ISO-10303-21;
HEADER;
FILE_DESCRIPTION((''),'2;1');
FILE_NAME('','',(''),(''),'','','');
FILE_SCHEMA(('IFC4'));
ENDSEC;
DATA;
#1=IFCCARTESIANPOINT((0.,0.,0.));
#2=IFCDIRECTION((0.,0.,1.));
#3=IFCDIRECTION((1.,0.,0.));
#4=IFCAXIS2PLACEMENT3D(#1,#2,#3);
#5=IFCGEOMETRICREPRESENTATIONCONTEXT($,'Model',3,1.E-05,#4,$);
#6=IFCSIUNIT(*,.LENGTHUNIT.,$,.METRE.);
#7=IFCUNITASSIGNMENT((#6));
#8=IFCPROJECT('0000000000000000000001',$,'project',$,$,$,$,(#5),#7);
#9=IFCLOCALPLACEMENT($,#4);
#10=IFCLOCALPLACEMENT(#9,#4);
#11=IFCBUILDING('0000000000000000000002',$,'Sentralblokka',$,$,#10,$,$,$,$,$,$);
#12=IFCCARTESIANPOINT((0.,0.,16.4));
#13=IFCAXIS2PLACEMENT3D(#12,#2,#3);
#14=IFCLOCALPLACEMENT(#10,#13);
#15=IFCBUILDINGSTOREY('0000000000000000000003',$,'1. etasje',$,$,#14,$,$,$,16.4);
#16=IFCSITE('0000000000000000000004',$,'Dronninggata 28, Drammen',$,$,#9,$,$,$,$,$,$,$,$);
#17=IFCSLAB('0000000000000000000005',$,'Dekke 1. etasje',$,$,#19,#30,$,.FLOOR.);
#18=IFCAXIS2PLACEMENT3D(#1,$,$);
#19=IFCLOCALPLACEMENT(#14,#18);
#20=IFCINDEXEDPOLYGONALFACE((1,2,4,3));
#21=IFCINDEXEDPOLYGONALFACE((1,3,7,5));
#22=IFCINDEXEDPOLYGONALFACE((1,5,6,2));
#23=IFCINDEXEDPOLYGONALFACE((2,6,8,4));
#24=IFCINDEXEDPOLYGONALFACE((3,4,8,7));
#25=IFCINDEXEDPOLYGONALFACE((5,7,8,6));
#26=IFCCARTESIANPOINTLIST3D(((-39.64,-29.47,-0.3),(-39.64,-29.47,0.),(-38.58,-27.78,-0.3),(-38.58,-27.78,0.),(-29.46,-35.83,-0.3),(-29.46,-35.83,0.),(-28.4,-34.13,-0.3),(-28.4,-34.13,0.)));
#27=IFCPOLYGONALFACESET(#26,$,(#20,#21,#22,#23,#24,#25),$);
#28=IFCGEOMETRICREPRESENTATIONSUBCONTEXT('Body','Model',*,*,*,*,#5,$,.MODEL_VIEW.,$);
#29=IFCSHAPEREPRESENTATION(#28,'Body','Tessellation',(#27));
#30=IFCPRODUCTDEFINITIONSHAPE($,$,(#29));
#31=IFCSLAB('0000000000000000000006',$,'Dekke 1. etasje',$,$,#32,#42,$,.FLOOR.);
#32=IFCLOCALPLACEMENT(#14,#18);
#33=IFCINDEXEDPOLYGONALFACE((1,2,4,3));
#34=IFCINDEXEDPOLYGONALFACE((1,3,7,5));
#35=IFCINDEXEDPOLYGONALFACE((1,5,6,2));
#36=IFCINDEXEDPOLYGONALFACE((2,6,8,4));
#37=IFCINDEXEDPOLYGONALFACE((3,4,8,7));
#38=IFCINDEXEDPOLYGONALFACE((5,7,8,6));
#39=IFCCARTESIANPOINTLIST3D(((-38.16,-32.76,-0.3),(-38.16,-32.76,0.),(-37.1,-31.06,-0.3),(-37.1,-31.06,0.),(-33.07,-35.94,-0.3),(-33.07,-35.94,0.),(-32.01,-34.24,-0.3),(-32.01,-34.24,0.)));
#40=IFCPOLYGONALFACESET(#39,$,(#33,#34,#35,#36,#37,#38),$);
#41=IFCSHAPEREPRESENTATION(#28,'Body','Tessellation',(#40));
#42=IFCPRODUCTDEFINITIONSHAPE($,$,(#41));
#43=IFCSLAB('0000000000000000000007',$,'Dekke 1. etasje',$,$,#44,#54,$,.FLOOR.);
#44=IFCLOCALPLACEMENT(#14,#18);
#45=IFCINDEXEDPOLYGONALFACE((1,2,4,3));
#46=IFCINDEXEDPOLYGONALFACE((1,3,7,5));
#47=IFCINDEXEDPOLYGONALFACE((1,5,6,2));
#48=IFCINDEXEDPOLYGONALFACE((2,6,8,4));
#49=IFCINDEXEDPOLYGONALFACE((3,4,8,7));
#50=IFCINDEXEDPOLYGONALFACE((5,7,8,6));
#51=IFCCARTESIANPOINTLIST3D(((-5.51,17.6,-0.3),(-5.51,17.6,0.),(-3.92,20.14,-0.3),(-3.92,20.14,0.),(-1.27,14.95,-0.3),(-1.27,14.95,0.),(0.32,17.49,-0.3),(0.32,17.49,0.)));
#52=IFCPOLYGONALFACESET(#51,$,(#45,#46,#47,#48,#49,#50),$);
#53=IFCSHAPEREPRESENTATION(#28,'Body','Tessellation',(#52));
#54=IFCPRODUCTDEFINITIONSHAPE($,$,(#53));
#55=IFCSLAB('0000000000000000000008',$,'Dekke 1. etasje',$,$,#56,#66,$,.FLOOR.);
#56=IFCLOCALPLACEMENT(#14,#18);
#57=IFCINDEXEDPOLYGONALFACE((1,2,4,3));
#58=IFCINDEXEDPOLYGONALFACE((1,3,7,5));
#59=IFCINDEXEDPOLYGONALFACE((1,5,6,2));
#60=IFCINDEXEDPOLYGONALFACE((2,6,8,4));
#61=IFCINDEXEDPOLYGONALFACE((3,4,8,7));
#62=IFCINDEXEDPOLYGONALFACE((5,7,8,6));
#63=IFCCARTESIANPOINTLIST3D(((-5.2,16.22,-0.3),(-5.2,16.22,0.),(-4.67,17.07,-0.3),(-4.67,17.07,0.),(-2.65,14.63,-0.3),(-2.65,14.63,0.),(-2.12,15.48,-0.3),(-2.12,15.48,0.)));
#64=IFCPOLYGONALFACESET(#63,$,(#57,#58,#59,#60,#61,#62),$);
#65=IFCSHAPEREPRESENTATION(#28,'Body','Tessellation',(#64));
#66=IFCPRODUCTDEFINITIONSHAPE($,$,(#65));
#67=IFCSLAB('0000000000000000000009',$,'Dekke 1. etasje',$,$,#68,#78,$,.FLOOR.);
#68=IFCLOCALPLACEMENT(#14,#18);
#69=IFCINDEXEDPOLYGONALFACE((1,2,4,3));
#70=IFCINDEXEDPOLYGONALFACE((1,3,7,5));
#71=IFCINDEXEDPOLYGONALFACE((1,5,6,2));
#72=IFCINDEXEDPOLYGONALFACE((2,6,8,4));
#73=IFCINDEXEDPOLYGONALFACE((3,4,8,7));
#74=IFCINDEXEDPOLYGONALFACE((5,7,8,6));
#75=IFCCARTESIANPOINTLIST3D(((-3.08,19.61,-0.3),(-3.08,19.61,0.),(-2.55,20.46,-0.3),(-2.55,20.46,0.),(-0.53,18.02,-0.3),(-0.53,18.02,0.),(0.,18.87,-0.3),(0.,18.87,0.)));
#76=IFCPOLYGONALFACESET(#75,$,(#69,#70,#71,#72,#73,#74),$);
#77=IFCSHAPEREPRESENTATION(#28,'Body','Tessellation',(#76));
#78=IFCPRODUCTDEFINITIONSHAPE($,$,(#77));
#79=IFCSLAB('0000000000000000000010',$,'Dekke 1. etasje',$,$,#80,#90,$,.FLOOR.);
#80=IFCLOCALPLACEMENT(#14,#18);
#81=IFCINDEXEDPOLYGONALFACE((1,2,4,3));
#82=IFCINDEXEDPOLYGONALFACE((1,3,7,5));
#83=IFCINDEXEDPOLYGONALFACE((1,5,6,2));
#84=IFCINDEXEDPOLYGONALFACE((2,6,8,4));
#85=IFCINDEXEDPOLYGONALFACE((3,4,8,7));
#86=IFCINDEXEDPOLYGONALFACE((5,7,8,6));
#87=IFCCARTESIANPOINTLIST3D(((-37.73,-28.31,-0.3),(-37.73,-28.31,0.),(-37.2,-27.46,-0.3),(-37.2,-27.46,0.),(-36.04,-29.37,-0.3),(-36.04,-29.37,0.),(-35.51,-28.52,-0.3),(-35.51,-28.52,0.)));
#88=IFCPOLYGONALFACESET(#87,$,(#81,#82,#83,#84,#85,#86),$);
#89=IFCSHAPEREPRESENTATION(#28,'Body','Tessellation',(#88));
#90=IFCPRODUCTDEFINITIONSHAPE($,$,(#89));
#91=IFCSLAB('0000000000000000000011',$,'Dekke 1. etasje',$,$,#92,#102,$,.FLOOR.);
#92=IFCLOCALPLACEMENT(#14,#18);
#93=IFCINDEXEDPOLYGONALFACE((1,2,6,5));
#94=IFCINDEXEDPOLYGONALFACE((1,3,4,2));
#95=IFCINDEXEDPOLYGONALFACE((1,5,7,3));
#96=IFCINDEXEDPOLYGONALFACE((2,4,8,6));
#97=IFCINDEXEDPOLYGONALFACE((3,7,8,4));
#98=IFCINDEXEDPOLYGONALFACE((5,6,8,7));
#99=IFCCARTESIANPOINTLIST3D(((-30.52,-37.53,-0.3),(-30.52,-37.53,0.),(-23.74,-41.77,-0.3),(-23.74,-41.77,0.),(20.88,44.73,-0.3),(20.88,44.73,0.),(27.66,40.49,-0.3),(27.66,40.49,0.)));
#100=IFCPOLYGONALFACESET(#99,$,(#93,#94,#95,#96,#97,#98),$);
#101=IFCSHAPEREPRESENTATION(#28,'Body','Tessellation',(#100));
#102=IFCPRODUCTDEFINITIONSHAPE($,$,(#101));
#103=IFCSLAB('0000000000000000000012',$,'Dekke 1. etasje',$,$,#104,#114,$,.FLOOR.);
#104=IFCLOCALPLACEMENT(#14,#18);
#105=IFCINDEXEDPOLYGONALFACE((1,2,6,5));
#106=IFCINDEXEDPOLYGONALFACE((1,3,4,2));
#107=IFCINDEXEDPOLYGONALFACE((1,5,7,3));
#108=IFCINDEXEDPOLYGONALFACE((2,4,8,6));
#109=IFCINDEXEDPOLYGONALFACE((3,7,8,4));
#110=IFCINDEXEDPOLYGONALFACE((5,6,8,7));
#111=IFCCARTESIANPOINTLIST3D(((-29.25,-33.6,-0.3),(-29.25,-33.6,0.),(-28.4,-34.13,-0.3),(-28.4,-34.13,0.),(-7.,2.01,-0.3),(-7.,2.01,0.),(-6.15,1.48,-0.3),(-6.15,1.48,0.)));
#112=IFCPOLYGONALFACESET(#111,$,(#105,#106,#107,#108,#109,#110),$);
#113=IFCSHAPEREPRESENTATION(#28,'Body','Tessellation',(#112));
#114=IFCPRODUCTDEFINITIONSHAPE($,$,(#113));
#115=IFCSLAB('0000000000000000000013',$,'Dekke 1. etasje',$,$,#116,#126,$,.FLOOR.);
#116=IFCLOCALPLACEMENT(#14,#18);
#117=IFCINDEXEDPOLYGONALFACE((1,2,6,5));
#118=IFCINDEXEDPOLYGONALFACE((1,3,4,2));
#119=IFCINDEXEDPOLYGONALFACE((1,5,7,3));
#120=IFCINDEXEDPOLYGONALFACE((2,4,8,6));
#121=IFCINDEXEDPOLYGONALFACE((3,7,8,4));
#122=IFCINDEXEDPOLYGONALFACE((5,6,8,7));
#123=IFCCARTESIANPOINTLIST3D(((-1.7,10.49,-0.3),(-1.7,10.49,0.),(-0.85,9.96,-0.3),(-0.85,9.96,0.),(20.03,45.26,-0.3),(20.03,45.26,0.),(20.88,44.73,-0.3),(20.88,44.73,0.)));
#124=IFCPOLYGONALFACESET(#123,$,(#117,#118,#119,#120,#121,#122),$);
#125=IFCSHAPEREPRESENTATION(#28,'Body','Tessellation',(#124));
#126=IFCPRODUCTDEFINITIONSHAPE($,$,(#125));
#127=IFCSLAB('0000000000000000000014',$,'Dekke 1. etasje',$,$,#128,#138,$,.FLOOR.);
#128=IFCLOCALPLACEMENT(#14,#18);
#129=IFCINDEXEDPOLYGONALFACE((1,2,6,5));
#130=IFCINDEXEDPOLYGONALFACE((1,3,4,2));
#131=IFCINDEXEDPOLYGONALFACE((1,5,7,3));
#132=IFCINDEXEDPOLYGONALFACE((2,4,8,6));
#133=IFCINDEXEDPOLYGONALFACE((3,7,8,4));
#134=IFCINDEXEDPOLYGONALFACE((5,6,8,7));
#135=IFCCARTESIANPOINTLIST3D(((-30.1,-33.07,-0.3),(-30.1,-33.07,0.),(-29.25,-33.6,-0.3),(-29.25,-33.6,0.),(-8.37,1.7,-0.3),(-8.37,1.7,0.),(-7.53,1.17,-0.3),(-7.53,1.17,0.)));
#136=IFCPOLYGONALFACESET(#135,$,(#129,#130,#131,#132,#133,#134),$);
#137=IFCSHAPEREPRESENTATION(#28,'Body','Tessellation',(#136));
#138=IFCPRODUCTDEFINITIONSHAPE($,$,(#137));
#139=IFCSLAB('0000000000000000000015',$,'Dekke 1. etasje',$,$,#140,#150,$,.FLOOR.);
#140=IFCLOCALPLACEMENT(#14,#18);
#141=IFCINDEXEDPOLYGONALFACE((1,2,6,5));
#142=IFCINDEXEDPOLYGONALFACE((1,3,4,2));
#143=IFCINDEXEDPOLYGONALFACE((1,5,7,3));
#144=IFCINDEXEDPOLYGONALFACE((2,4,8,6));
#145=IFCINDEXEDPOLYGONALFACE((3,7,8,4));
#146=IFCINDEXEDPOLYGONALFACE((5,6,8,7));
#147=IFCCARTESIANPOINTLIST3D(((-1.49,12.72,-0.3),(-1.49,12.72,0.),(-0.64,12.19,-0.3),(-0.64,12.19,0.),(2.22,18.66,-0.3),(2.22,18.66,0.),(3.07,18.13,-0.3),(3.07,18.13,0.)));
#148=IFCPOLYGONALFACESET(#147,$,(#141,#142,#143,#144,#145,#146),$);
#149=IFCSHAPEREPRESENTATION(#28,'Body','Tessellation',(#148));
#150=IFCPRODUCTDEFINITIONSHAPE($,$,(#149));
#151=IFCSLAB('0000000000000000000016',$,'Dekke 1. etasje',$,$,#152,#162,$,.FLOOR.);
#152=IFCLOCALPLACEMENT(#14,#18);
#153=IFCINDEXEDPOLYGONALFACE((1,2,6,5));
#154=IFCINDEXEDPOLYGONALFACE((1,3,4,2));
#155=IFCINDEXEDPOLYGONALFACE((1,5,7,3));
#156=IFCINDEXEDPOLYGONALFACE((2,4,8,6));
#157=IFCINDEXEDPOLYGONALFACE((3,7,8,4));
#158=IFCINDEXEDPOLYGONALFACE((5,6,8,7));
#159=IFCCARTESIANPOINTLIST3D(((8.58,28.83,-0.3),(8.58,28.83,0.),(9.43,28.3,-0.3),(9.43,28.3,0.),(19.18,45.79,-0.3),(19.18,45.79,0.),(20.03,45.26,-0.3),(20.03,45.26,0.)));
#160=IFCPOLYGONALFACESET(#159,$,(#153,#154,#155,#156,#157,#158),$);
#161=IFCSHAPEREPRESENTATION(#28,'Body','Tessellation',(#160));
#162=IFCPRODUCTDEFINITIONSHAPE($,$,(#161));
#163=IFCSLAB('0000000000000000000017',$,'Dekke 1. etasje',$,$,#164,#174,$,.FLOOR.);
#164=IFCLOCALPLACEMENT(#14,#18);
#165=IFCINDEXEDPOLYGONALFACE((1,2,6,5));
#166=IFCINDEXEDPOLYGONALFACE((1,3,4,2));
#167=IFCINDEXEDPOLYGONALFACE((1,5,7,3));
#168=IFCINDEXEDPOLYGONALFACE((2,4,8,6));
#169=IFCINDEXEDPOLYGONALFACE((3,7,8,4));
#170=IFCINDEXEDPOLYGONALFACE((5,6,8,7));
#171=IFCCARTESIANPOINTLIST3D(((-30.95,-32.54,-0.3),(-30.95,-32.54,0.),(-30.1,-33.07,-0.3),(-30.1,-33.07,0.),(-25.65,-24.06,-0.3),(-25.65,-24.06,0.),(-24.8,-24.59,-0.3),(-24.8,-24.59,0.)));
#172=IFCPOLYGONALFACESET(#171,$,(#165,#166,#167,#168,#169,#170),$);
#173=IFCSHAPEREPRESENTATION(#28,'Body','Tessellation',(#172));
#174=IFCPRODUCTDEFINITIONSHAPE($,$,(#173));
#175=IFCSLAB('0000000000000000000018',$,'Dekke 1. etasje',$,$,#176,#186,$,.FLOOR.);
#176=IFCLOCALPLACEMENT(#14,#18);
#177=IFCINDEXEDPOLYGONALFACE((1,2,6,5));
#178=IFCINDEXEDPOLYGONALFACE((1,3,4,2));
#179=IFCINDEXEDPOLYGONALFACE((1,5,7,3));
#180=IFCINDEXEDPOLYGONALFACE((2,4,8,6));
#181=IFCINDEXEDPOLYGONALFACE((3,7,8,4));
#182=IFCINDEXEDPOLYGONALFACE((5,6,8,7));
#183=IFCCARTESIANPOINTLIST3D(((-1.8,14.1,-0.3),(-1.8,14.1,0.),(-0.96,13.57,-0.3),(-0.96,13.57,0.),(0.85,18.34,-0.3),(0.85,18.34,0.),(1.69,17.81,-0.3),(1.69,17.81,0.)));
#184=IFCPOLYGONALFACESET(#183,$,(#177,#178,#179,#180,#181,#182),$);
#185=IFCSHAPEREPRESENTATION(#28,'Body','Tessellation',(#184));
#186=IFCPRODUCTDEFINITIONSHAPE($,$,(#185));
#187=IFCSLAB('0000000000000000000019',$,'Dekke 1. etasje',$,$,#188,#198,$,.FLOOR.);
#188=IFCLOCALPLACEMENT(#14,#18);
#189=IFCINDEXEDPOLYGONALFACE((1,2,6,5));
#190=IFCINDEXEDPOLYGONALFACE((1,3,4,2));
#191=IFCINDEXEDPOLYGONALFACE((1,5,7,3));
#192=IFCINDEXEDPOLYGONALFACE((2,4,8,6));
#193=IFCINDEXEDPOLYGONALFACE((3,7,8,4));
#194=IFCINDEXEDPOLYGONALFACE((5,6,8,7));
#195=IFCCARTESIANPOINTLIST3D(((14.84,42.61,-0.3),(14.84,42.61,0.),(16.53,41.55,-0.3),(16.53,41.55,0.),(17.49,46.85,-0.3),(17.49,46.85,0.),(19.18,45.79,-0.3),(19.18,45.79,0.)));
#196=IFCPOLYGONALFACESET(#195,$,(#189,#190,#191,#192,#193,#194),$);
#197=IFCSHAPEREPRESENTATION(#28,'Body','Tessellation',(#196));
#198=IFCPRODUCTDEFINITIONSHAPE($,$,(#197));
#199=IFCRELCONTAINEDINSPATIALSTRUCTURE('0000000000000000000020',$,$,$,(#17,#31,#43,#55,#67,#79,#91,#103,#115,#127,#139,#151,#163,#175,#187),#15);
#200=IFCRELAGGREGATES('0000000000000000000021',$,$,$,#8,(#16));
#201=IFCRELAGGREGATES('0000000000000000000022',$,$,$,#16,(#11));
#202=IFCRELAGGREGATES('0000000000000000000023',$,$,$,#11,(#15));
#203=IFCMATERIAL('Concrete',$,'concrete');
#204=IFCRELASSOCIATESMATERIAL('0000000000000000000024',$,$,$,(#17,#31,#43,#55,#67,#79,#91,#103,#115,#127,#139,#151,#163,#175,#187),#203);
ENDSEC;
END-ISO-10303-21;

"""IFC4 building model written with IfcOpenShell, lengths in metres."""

from ifc_helpers import new_model, si_unit, frame, origin_with_axes, place, context, subcontext, project, spatial, polyline, outline, extrude, material, element, save


model = new_model("IFC4")

# Units and contexts
model_context = context("Model", 3, precision=1e-05, world=origin_with_axes())
body_context = subcontext(model_context, "Body", "Model", "MODEL_VIEW")
ifc_project = project(units=[si_unit("LENGTHUNIT", "METRE")], contexts=[model_context])

# Site, building, storey
site_placement = place(None, origin_with_axes())
site = spatial("IfcSite", under=ifc_project, at=site_placement, Name="Dronninggata 28, Drammen")
building_placement = place(site_placement, origin_with_axes())
building = spatial("IfcBuilding", under=site, at=building_placement, Name="Sentralblokka")
storey_placement = place(building_placement, frame((0.0, 0.0, 16.4), z_axis=(0.0, 0.0, 1.0), x_axis=(1.0, 0.0, 0.0)))
storey = spatial("IfcBuildingStorey", under=building, at=storey_placement, Name="1. etasje", Elevation=16.4)

# Slabs
ifc_material_1 = material(Name="Concrete", Category="concrete")
slab_1_placement = place(storey_placement, frame((0.0, 0.0, -16.4), z_axis=(0.0, 0.0, 1.0), x_axis=(1.0, 0.0, 0.0)))
element("IfcSlab", 1, at=slab_1_placement, inside=storey, material=ifc_material_1, Name="Dekke 1. etasje", PredefinedType="FLOOR", context=body_context, shape_type="SweptSolid", body=[
    extrude(outline(polyline([(-29.46, -35.83), (-28.4, -34.13), (-38.58, -27.78), (-39.64, -29.47), (-29.46, -35.83)])), frame((0.0, 0.0, 16.1)), (0.0, 0.0, 1.0), 0.3),
])
slab_2_placement = place(storey_placement, frame((0.0, 0.0, -16.4), z_axis=(0.0, 0.0, 1.0), x_axis=(1.0, 0.0, 0.0)))
element("IfcSlab", 2, at=slab_2_placement, inside=storey, material=ifc_material_1, Name="Dekke 1. etasje", PredefinedType="FLOOR", context=body_context, shape_type="SweptSolid", body=[
    extrude(outline(polyline([(-33.07, -35.94), (-32.01, -34.24), (-37.1, -31.06), (-38.16, -32.76), (-33.07, -35.94)])), frame((0.0, 0.0, 16.1)), (0.0, 0.0, 1.0), 0.3),
])
slab_3_placement = place(storey_placement, frame((0.0, 0.0, -16.4), z_axis=(0.0, 0.0, 1.0), x_axis=(1.0, 0.0, 0.0)))
element("IfcSlab", 3, at=slab_3_placement, inside=storey, material=ifc_material_1, Name="Dekke 1. etasje", PredefinedType="FLOOR", context=body_context, shape_type="SweptSolid", body=[
    extrude(outline(polyline([(-1.27, 14.95), (0.32, 17.49), (-3.92, 20.14), (-5.51, 17.6), (-1.27, 14.95)])), frame((0.0, 0.0, 16.1)), (0.0, 0.0, 1.0), 0.3),
])
slab_4_placement = place(storey_placement, frame((0.0, 0.0, -16.4), z_axis=(0.0, 0.0, 1.0), x_axis=(1.0, 0.0, 0.0)))
element("IfcSlab", 4, at=slab_4_placement, inside=storey, material=ifc_material_1, Name="Dekke 1. etasje", PredefinedType="FLOOR", context=body_context, shape_type="SweptSolid", body=[
    extrude(outline(polyline([(-2.65, 14.63), (-2.12, 15.48), (-4.67, 17.07), (-5.2, 16.22), (-2.65, 14.63)])), frame((0.0, 0.0, 16.1)), (0.0, 0.0, 1.0), 0.3),
])
slab_5_placement = place(storey_placement, frame((0.0, 0.0, -16.4), z_axis=(0.0, 0.0, 1.0), x_axis=(1.0, 0.0, 0.0)))
element("IfcSlab", 5, at=slab_5_placement, inside=storey, material=ifc_material_1, Name="Dekke 1. etasje", PredefinedType="FLOOR", context=body_context, shape_type="SweptSolid", body=[
    extrude(outline(polyline([(-0.53, 18.02), (0.0, 18.87), (-2.55, 20.46), (-3.08, 19.61), (-0.53, 18.02)])), frame((0.0, 0.0, 16.1)), (0.0, 0.0, 1.0), 0.3),
])
slab_6_placement = place(storey_placement, frame((0.0, 0.0, -16.4), z_axis=(0.0, 0.0, 1.0), x_axis=(1.0, 0.0, 0.0)))
element("IfcSlab", 6, at=slab_6_placement, inside=storey, material=ifc_material_1, Name="Dekke 1. etasje", PredefinedType="FLOOR", context=body_context, shape_type="SweptSolid", body=[
    extrude(outline(polyline([(-36.04, -29.37), (-35.51, -28.52), (-37.2, -27.46), (-37.73, -28.31), (-36.04, -29.37)])), frame((0.0, 0.0, 16.1)), (0.0, 0.0, 1.0), 0.3),
])
slab_7_placement = place(storey_placement, frame((0.0, 0.0, -16.4), z_axis=(0.0, 0.0, 1.0), x_axis=(1.0, 0.0, 0.0)))
element("IfcSlab", 7, at=slab_7_placement, inside=storey, material=ifc_material_1, Name="Dekke 1. etasje", PredefinedType="FLOOR", context=body_context, shape_type="SweptSolid", body=[
    extrude(outline(polyline([(-23.74, -41.77), (27.66, 40.49), (20.88, 44.73), (-30.52, -37.53), (-23.74, -41.77)])), frame((0.0, 0.0, 16.1)), (0.0, 0.0, 1.0), 0.3),
])
slab_8_placement = place(storey_placement, frame((0.0, 0.0, -16.4), z_axis=(0.0, 0.0, 1.0), x_axis=(1.0, 0.0, 0.0)))
element("IfcSlab", 8, at=slab_8_placement, inside=storey, material=ifc_material_1, Name="Dekke 1. etasje", PredefinedType="FLOOR", context=body_context, shape_type="SweptSolid", body=[
    extrude(outline(polyline([(-28.4, -34.13), (-6.15, 1.48), (-7.0, 2.01), (-29.25, -33.6), (-28.4, -34.13)])), frame((0.0, 0.0, 16.1)), (0.0, 0.0, 1.0), 0.3),
])
slab_9_placement = place(storey_placement, frame((0.0, 0.0, -16.4), z_axis=(0.0, 0.0, 1.0), x_axis=(1.0, 0.0, 0.0)))
element("IfcSlab", 9, at=slab_9_placement, inside=storey, material=ifc_material_1, Name="Dekke 1. etasje", PredefinedType="FLOOR", context=body_context, shape_type="SweptSolid", body=[
    extrude(outline(polyline([(-0.85, 9.96), (20.88, 44.73), (20.03, 45.26), (-1.7, 10.49), (-0.85, 9.96)])), frame((0.0, 0.0, 16.1)), (0.0, 0.0, 1.0), 0.3),
])
slab_10_placement = place(storey_placement, frame((0.0, 0.0, -16.4), z_axis=(0.0, 0.0, 1.0), x_axis=(1.0, 0.0, 0.0)))
element("IfcSlab", 10, at=slab_10_placement, inside=storey, material=ifc_material_1, Name="Dekke 1. etasje", PredefinedType="FLOOR", context=body_context, shape_type="SweptSolid", body=[
    extrude(outline(polyline([(-29.25, -33.6), (-7.53, 1.17), (-8.37, 1.7), (-30.1, -33.07), (-29.25, -33.6)])), frame((0.0, 0.0, 16.1)), (0.0, 0.0, 1.0), 0.3),
])
slab_11_placement = place(storey_placement, frame((0.0, 0.0, -16.4), z_axis=(0.0, 0.0, 1.0), x_axis=(1.0, 0.0, 0.0)))
element("IfcSlab", 11, at=slab_11_placement, inside=storey, material=ifc_material_1, Name="Dekke 1. etasje", PredefinedType="FLOOR", context=body_context, shape_type="SweptSolid", body=[
    extrude(outline(polyline([(-0.64, 12.19), (3.07, 18.13), (2.22, 18.66), (-1.49, 12.72), (-0.64, 12.19)])), frame((0.0, 0.0, 16.1)), (0.0, 0.0, 1.0), 0.3),
])
slab_12_placement = place(storey_placement, frame((0.0, 0.0, -16.4), z_axis=(0.0, 0.0, 1.0), x_axis=(1.0, 0.0, 0.0)))
element("IfcSlab", 12, at=slab_12_placement, inside=storey, material=ifc_material_1, Name="Dekke 1. etasje", PredefinedType="FLOOR", context=body_context, shape_type="SweptSolid", body=[
    extrude(outline(polyline([(9.43, 28.3), (20.03, 45.26), (19.18, 45.79), (8.58, 28.83), (9.43, 28.3)])), frame((0.0, 0.0, 16.1)), (0.0, 0.0, 1.0), 0.3),
])
slab_13_placement = place(storey_placement, frame((0.0, 0.0, -16.4), z_axis=(0.0, 0.0, 1.0), x_axis=(1.0, 0.0, 0.0)))
element("IfcSlab", 13, at=slab_13_placement, inside=storey, material=ifc_material_1, Name="Dekke 1. etasje", PredefinedType="FLOOR", context=body_context, shape_type="SweptSolid", body=[
    extrude(outline(polyline([(-30.1, -33.07), (-24.8, -24.59), (-25.65, -24.06), (-30.95, -32.54), (-30.1, -33.07)])), frame((0.0, 0.0, 16.1)), (0.0, 0.0, 1.0), 0.3),
])
slab_14_placement = place(storey_placement, frame((0.0, 0.0, -16.4), z_axis=(0.0, 0.0, 1.0), x_axis=(1.0, 0.0, 0.0)))
element("IfcSlab", 14, at=slab_14_placement, inside=storey, material=ifc_material_1, Name="Dekke 1. etasje", PredefinedType="FLOOR", context=body_context, shape_type="SweptSolid", body=[
    extrude(outline(polyline([(-0.96, 13.57), (1.69, 17.81), (0.85, 18.34), (-1.8, 14.1), (-0.96, 13.57)])), frame((0.0, 0.0, 16.1)), (0.0, 0.0, 1.0), 0.3),
])
slab_15_placement = place(storey_placement, frame((0.0, 0.0, -16.4), z_axis=(0.0, 0.0, 1.0), x_axis=(1.0, 0.0, 0.0)))
element("IfcSlab", 15, at=slab_15_placement, inside=storey, material=ifc_material_1, Name="Dekke 1. etasje", PredefinedType="FLOOR", context=body_context, shape_type="SweptSolid", body=[
    extrude(outline(polyline([(16.53, 41.55), (19.18, 45.79), (17.49, 46.85), (14.84, 42.61), (16.53, 41.55)])), frame((0.0, 0.0, 16.1)), (0.0, 0.0, 1.0), 0.3),
])

save(model, "model.ifc")
